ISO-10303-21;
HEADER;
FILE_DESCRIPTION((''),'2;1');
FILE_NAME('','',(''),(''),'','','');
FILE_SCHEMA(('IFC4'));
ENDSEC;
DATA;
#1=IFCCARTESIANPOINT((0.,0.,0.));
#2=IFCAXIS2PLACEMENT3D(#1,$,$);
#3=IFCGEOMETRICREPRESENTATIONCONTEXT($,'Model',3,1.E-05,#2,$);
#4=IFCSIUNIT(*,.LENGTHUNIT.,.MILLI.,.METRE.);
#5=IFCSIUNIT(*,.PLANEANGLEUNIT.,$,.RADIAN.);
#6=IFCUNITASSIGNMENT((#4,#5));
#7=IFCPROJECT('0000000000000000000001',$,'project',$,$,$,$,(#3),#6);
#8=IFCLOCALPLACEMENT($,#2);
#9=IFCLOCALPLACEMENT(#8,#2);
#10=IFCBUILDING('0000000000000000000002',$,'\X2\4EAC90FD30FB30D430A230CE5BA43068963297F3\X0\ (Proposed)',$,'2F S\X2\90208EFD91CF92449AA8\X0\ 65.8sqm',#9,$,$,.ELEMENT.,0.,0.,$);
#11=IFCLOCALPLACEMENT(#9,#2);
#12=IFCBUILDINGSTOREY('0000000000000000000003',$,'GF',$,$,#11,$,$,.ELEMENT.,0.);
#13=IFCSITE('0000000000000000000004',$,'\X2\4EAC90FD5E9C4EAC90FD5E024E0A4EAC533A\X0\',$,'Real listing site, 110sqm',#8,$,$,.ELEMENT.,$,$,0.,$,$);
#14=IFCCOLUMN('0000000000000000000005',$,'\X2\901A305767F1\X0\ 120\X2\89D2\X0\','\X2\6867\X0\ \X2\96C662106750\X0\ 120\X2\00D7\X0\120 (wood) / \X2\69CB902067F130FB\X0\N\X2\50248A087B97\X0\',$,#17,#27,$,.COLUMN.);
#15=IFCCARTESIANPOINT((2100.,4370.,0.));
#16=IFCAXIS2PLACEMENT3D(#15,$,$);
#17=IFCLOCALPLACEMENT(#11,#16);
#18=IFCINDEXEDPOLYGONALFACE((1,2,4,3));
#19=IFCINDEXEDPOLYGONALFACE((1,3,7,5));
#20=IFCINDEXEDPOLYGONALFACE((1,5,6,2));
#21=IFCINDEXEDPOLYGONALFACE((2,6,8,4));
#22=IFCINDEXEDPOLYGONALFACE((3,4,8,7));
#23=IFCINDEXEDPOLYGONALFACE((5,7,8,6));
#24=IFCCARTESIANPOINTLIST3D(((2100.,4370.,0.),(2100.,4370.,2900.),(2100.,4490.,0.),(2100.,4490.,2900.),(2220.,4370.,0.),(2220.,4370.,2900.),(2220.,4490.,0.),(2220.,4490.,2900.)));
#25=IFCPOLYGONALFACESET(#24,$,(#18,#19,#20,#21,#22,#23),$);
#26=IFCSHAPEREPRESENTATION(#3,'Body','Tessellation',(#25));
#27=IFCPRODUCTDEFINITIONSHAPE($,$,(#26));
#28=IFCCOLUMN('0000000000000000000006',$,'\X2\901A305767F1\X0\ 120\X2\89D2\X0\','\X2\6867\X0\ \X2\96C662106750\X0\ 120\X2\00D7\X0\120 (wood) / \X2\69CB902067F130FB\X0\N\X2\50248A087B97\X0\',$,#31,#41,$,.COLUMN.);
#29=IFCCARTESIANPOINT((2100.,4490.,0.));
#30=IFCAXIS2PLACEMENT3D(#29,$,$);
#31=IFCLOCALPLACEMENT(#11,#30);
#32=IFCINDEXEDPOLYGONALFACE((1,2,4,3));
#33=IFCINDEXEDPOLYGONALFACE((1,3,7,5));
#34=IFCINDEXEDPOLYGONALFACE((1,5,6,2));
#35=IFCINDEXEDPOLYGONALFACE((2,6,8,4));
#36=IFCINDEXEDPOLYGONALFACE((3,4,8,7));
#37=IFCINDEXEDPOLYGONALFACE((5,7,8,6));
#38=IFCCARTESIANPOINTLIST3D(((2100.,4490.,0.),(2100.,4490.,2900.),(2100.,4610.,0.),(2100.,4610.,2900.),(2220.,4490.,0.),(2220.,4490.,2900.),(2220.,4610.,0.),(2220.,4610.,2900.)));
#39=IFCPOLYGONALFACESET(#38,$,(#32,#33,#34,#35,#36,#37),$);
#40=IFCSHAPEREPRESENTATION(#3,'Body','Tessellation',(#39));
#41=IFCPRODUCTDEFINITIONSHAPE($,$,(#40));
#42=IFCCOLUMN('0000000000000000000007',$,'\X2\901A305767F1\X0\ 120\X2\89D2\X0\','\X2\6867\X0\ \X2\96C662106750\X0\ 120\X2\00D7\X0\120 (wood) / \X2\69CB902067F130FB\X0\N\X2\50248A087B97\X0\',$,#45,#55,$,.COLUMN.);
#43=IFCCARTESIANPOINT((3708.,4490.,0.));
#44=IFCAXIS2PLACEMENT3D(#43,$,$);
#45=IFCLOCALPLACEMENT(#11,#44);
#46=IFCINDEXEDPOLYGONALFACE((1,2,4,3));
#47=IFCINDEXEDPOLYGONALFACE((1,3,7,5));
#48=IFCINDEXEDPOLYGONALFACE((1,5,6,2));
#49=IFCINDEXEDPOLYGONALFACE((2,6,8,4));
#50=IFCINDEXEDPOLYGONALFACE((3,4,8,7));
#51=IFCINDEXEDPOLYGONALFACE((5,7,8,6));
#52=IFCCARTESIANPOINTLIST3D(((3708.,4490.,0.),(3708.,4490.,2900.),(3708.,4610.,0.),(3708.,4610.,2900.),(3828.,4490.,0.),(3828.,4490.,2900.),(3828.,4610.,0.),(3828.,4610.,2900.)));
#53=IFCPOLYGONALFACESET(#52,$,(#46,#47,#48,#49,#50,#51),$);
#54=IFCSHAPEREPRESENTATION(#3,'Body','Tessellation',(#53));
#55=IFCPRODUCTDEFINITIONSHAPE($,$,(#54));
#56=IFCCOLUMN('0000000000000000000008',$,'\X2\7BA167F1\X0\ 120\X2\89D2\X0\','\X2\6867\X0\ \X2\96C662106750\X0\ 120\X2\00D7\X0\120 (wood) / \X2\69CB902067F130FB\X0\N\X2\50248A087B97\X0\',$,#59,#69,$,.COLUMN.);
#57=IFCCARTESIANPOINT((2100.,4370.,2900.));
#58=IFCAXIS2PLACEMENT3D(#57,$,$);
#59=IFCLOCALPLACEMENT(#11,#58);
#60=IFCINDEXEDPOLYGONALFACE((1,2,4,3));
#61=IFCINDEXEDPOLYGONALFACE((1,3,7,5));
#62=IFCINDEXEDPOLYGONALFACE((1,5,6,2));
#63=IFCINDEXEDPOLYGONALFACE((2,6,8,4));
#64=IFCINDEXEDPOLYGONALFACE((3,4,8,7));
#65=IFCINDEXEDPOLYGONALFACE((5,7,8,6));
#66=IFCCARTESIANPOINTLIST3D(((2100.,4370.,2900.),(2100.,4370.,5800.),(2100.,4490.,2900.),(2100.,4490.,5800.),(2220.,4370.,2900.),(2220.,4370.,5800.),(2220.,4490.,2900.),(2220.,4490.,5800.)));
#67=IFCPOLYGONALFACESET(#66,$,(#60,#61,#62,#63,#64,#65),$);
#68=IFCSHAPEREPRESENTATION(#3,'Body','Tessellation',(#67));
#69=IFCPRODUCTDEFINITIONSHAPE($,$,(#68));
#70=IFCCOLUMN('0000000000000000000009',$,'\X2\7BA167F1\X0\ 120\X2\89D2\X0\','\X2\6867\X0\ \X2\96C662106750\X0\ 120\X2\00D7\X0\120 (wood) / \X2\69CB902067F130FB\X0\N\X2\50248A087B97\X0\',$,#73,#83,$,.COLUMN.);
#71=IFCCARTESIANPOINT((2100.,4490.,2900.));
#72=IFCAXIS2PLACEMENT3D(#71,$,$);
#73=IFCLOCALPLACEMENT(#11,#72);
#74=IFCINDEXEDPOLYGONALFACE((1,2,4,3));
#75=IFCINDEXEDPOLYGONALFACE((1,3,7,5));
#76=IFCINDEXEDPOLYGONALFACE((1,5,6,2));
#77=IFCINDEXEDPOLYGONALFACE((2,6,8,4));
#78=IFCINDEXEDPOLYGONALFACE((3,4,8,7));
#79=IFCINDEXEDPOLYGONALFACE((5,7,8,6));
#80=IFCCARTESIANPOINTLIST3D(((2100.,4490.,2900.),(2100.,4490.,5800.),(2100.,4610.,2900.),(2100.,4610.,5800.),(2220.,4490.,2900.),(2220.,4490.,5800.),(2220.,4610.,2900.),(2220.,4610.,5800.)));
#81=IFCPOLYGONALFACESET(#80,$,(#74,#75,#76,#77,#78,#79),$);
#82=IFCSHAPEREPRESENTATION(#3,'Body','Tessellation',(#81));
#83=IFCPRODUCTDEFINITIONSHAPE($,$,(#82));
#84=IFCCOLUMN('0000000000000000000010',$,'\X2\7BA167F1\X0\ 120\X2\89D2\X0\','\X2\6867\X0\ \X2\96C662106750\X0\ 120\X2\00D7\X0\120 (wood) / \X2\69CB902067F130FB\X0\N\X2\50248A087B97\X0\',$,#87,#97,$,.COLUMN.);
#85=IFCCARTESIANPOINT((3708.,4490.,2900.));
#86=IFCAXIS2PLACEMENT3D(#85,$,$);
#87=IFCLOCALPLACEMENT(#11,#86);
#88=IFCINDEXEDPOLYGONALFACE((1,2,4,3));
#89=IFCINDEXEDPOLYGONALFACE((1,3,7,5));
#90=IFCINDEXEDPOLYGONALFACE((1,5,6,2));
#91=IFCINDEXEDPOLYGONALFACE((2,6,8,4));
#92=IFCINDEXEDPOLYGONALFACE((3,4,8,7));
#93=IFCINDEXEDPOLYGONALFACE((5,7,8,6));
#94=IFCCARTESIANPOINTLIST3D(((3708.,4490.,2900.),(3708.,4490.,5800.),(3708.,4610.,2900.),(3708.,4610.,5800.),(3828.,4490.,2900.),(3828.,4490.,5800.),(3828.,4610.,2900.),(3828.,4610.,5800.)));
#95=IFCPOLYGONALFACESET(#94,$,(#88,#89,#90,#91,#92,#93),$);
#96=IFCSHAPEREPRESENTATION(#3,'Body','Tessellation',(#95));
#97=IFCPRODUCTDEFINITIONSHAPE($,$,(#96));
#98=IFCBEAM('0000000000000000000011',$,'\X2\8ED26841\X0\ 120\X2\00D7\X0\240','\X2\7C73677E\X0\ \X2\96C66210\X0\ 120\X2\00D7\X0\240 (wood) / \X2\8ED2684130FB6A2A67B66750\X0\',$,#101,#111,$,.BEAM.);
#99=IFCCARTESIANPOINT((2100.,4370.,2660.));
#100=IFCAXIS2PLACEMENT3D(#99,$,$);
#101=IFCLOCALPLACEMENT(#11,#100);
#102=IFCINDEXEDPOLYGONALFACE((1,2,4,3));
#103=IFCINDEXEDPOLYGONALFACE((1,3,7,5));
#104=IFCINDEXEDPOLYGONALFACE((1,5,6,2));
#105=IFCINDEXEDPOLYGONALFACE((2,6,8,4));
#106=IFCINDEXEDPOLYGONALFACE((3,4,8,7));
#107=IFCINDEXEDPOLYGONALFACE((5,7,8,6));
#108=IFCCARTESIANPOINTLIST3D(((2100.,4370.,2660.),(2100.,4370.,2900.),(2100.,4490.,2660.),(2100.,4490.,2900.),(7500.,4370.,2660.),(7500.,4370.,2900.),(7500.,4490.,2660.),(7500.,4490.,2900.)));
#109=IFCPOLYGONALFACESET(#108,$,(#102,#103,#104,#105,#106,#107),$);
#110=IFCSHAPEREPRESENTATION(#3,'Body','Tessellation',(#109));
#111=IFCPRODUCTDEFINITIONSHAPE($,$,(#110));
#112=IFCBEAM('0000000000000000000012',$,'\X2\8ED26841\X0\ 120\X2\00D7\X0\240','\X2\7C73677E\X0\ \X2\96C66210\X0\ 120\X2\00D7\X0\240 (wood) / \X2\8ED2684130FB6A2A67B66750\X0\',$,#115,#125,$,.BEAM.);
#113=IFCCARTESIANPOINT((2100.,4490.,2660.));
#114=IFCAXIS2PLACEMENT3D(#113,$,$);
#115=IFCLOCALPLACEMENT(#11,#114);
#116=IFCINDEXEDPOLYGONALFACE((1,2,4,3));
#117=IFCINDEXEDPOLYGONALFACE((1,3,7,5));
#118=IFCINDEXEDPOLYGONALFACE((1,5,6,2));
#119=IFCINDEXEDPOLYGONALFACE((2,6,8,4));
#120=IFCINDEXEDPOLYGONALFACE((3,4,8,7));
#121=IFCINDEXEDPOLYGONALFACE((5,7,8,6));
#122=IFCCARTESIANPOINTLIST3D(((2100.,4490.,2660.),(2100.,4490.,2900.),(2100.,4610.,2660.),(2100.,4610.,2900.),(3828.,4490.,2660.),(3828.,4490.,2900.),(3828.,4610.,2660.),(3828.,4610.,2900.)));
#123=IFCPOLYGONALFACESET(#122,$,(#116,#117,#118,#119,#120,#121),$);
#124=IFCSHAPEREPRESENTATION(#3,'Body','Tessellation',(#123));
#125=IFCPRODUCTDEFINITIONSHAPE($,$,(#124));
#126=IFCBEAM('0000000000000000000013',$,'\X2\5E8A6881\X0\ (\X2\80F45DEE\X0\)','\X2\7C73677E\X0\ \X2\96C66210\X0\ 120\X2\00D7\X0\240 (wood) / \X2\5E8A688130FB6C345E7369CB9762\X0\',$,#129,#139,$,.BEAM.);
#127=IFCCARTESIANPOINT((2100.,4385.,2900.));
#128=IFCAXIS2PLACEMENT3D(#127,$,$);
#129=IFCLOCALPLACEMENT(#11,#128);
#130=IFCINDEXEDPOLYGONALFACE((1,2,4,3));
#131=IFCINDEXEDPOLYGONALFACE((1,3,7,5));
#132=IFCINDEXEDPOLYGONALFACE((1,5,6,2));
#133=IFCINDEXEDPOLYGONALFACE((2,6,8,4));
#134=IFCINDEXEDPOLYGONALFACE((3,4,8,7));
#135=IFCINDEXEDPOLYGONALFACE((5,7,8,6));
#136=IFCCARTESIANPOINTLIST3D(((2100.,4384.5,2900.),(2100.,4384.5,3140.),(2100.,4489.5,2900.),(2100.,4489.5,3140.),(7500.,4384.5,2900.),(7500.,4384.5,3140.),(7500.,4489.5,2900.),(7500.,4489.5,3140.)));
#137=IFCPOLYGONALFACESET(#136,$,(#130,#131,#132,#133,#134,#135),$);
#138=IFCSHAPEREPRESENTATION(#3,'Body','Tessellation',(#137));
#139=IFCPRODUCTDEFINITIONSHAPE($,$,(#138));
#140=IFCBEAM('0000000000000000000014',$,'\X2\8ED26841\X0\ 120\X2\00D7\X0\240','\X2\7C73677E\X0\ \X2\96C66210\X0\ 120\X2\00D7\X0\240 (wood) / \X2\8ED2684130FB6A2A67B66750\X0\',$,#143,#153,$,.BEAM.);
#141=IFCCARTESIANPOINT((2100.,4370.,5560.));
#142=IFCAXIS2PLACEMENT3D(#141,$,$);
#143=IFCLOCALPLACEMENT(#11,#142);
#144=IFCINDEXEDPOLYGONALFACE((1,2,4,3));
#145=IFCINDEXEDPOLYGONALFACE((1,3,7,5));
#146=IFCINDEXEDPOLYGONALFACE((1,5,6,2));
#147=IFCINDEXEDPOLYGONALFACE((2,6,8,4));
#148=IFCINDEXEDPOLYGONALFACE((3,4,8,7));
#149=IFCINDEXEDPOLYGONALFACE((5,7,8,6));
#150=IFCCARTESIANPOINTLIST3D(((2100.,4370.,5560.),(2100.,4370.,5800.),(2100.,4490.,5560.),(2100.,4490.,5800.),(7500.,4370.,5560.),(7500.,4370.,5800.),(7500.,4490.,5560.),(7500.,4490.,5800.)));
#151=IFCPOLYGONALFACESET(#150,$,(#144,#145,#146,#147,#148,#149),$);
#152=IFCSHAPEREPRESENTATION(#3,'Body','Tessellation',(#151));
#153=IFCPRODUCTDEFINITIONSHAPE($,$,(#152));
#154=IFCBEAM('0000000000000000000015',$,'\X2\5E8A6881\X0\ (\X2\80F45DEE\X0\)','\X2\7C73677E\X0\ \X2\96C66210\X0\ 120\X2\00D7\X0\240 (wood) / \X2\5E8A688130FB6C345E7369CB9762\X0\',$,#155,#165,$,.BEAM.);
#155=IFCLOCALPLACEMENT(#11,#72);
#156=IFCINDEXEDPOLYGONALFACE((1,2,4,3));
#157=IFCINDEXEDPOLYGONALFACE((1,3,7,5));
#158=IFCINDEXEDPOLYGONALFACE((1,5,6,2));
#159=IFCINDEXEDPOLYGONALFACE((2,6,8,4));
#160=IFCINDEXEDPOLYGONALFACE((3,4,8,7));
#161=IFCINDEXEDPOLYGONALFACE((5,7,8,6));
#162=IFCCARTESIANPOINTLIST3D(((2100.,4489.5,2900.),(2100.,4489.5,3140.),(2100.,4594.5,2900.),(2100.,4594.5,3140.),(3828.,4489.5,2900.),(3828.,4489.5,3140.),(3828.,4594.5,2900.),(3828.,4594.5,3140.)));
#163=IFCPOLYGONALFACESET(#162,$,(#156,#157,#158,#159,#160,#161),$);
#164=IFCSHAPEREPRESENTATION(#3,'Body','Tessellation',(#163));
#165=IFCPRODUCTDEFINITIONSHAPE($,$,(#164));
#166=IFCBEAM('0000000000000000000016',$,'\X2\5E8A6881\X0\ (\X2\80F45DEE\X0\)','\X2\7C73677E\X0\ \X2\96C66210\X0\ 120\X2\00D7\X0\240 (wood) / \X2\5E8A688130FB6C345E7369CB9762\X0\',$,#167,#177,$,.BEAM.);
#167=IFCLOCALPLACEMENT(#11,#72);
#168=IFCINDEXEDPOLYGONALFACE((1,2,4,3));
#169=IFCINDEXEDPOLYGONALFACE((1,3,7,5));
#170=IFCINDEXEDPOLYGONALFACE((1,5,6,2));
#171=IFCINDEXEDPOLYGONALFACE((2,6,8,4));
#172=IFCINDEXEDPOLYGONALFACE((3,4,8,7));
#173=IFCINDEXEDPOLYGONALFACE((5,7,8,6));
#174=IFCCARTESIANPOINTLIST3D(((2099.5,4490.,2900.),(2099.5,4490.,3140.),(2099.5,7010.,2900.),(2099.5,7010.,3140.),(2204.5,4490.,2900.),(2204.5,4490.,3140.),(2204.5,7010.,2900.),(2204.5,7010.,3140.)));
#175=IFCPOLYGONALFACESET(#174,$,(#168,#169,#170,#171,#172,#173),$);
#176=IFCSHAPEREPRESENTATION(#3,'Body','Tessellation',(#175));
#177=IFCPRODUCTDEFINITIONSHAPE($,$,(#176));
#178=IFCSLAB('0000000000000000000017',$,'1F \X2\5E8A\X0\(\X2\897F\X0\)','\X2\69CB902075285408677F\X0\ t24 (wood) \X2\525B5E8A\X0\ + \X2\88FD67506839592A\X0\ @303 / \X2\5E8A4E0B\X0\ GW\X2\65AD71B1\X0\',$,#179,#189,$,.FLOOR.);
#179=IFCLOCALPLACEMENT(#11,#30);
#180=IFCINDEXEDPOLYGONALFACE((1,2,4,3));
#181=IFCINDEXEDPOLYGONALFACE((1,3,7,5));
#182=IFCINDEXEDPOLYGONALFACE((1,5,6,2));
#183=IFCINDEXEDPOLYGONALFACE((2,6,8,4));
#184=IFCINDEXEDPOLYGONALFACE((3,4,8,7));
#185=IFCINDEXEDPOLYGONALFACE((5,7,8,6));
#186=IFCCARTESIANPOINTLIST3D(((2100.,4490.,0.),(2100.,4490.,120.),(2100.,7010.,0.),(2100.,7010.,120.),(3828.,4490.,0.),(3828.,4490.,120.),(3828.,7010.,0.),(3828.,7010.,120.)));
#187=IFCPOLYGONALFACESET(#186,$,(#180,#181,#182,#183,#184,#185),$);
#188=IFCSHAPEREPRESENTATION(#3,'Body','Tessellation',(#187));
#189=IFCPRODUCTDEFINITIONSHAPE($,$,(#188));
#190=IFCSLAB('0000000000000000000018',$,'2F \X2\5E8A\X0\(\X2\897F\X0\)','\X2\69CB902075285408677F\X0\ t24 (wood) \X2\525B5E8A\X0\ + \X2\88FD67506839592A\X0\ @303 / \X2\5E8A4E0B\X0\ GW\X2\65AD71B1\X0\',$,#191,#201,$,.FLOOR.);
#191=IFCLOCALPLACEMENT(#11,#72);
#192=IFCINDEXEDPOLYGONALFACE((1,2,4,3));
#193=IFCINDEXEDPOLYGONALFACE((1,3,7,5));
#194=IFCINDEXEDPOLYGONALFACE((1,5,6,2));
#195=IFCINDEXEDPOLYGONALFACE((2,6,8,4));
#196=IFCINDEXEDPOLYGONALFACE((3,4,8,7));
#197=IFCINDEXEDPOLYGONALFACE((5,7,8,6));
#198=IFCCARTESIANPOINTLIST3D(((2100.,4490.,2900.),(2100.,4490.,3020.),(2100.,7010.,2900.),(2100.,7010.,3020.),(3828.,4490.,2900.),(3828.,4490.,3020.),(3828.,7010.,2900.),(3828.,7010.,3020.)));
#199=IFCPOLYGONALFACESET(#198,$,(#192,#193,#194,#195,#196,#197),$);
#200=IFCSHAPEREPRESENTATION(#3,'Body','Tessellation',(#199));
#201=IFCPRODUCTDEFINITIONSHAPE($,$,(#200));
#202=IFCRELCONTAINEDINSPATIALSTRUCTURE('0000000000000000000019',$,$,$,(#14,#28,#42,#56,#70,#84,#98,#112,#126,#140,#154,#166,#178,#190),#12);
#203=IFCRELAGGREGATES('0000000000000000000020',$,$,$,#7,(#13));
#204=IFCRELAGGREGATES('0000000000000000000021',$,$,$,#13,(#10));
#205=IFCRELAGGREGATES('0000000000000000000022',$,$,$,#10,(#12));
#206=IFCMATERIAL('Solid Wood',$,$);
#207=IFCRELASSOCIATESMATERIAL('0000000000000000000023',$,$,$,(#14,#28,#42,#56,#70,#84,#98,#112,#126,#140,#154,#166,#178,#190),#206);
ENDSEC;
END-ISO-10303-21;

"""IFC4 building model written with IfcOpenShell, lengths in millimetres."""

from ifc_helpers import new_model, si_unit, frame, frame_2d, origin, place, context, project, spatial, rectangle, extrude, material, element, save


model = new_model("IFC4")

# Units and contexts
model_context = context("Model", 3, precision=1e-05, world=origin())
ifc_project = project(units=[si_unit("LENGTHUNIT", "METRE", prefix="MILLI"), si_unit("PLANEANGLEUNIT", "RADIAN")], contexts=[model_context])

# Site, building, storey
site_placement = place(None, origin())
site = spatial("IfcSite", under=ifc_project, at=site_placement, Name="京都府京都市上京区", ObjectType="Real listing site, 110sqm", CompositionType="ELEMENT", RefElevation=0.0)
building_placement = place(site_placement, origin())
building = spatial("IfcBuilding", under=site, at=building_placement, Name="京都・ピアノ室と防音 (Proposed)", ObjectType="2F S造軽量鉄骨 65.8sqm", CompositionType="ELEMENT", ElevationOfRefHeight=0.0, ElevationOfTerrain=0.0)
storey_placement = place(building_placement, origin())
storey = spatial("IfcBuildingStorey", under=building, at=storey_placement, Name="GF", CompositionType="ELEMENT", Elevation=0.0)

# Columns
ifc_material_1 = material(Name="Solid Wood")
column_1_placement = place(storey_placement, frame((2100.0, 4370.0, 0.0)))
element("IfcColumn", 1, at=column_1_placement, inside=storey, material=ifc_material_1, Name="通し柱 120角", Description="桧 集成材 120×120 (wood) / 構造柱・N値計算", PredefinedType="COLUMN", context=model_context, shape_type="SweptSolid", body=[
    extrude(rectangle(XDim=120.0, YDim=120.0, at=frame_2d((60.0, 60.0))), frame((2100.0, 4370.0, 0.0)), (0.0, 0.0, 1.0), 2900.0),
])
column_2_placement = place(storey_placement, frame((2100.0, 4490.0, 0.0)))
element("IfcColumn", 2, at=column_2_placement, inside=storey, material=ifc_material_1, Name="通し柱 120角", Description="桧 集成材 120×120 (wood) / 構造柱・N値計算", PredefinedType="COLUMN", context=model_context, shape_type="SweptSolid", body=[
    extrude(rectangle(XDim=120.0, YDim=120.0, at=frame_2d((60.0, 60.0))), frame((2100.0, 4490.0, 0.0)), (0.0, 0.0, 1.0), 2900.0),
])
column_3_placement = place(storey_placement, frame((3708.0, 4490.0, 0.0)))
element("IfcColumn", 3, at=column_3_placement, inside=storey, material=ifc_material_1, Name="通し柱 120角", Description="桧 集成材 120×120 (wood) / 構造柱・N値計算", PredefinedType="COLUMN", context=model_context, shape_type="SweptSolid", body=[
    extrude(rectangle(XDim=120.0, YDim=120.0, at=frame_2d((60.0, 60.0))), frame((3708.0, 4490.0, 0.0)), (0.0, 0.0, 1.0), 2900.0),
])
column_4_placement = place(storey_placement, frame((2100.0, 4370.0, 2900.0)))
element("IfcColumn", 4, at=column_4_placement, inside=storey, material=ifc_material_1, Name="管柱 120角", Description="桧 集成材 120×120 (wood) / 構造柱・N値計算", PredefinedType="COLUMN", context=model_context, shape_type="SweptSolid", body=[
    extrude(rectangle(XDim=120.0, YDim=120.0, at=frame_2d((60.0, 60.0))), frame((2100.0, 4370.0, 2900.0)), (0.0, 0.0, 1.0), 2900.0),
])
column_5_placement = place(storey_placement, frame((2100.0, 4490.0, 2900.0)))
element("IfcColumn", 5, at=column_5_placement, inside=storey, material=ifc_material_1, Name="管柱 120角", Description="桧 集成材 120×120 (wood) / 構造柱・N値計算", PredefinedType="COLUMN", context=model_context, shape_type="SweptSolid", body=[
    extrude(rectangle(XDim=120.0, YDim=120.0, at=frame_2d((60.0, 60.0))), frame((2100.0, 4490.0, 2900.0)), (0.0, 0.0, 1.0), 2900.0),
])
column_6_placement = place(storey_placement, frame((3708.0, 4490.0, 2900.0)))
element("IfcColumn", 6, at=column_6_placement, inside=storey, material=ifc_material_1, Name="管柱 120角", Description="桧 集成材 120×120 (wood) / 構造柱・N値計算", PredefinedType="COLUMN", context=model_context, shape_type="SweptSolid", body=[
    extrude(rectangle(XDim=120.0, YDim=120.0, at=frame_2d((60.0, 60.0))), frame((3708.0, 4490.0, 2900.0)), (0.0, 0.0, 1.0), 2900.0),
])

# Beams
beam_1_placement = place(storey_placement, frame((2100.0, 4370.0, 2660.0)))
element("IfcBeam", 7, at=beam_1_placement, inside=storey, material=ifc_material_1, Name="軒桁 120×240", Description="米松 集成 120×240 (wood) / 軒桁・横架材", PredefinedType="BEAM", context=model_context, shape_type="SweptSolid", body=[
    extrude(rectangle(XDim=5400.0, YDim=120.0, at=frame_2d((2700.0, 60.0))), frame((2100.0, 4370.0, 2660.0)), (0.0, 0.0, 1.0), 240.0),
])
beam_2_placement = place(storey_placement, frame((2100.0, 4490.0, 2660.0)))
element("IfcBeam", 8, at=beam_2_placement, inside=storey, material=ifc_material_1, Name="軒桁 120×240", Description="米松 集成 120×240 (wood) / 軒桁・横架材", PredefinedType="BEAM", context=model_context, shape_type="SweptSolid", body=[
    extrude(rectangle(XDim=1728.0, YDim=120.0, at=frame_2d((864.0, 60.0))), frame((2100.0, 4490.0, 2660.0)), (0.0, 0.0, 1.0), 240.0),
])
beam_3_placement = place(storey_placement, frame((2100.0, 4385.0, 2900.0)))
element("IfcBeam", 9, at=beam_3_placement, inside=storey, material=ifc_material_1, Name="床梁 (胴差)", Description="米松 集成 120×240 (wood) / 床梁・水平構面", PredefinedType="BEAM", context=model_context, shape_type="SweptSolid", body=[
    extrude(rectangle(XDim=5400.0, YDim=105.0, at=frame_2d((2700.0, 52.0))), frame((2100.0, 4385.0, 2900.0)), (0.0, 0.0, 1.0), 240.0),
])
beam_4_placement = place(storey_placement, frame((2100.0, 4370.0, 5560.0)))
element("IfcBeam", 10, at=beam_4_placement, inside=storey, material=ifc_material_1, Name="軒桁 120×240", Description="米松 集成 120×240 (wood) / 軒桁・横架材", PredefinedType="BEAM", context=model_context, shape_type="SweptSolid", body=[
    extrude(rectangle(XDim=5400.0, YDim=120.0, at=frame_2d((2700.0, 60.0))), frame((2100.0, 4370.0, 5560.0)), (0.0, 0.0, 1.0), 240.0),
])
beam_5_placement = place(storey_placement, frame((2100.0, 4490.0, 2900.0)))
element("IfcBeam", 11, at=beam_5_placement, inside=storey, material=ifc_material_1, Name="床梁 (胴差)", Description="米松 集成 120×240 (wood) / 床梁・水平構面", PredefinedType="BEAM", context=model_context, shape_type="SweptSolid", body=[
    extrude(rectangle(XDim=1728.0, YDim=105.0, at=frame_2d((864.0, 52.0))), frame((2100.0, 4490.0, 2900.0)), (0.0, 0.0, 1.0), 240.0),
])
beam_6_placement = place(storey_placement, frame((2100.0, 4490.0, 2900.0)))
element("IfcBeam", 12, at=beam_6_placement, inside=storey, material=ifc_material_1, Name="床梁 (胴差)", Description="米松 集成 120×240 (wood) / 床梁・水平構面", PredefinedType="BEAM", context=model_context, shape_type="SweptSolid", body=[
    extrude(rectangle(XDim=105.0, YDim=2520.0, at=frame_2d((52.0, 1260.0))), frame((2100.0, 4490.0, 2900.0)), (0.0, 0.0, 1.0), 240.0),
])

# Slabs
slab_1_placement = place(storey_placement, frame((2100.0, 4490.0, 0.0)))
element("IfcSlab", 13, at=slab_1_placement, inside=storey, material=ifc_material_1, Name="1F 床(西)", Description="構造用合板 t24 (wood) 剛床 + 製材根太 @303 / 床下 GW断熱", PredefinedType="FLOOR", context=model_context, shape_type="SweptSolid", body=[
    extrude(rectangle(XDim=1728.0, YDim=2520.0, at=frame_2d((864.0, 1260.0))), frame((2100.0, 4490.0, 0.0)), (0.0, 0.0, 1.0), 120.0),
])
slab_2_placement = place(storey_placement, frame((2100.0, 4490.0, 2900.0)))
element("IfcSlab", 14, at=slab_2_placement, inside=storey, material=ifc_material_1, Name="2F 床(西)", Description="構造用合板 t24 (wood) 剛床 + 製材根太 @303 / 床下 GW断熱", PredefinedType="FLOOR", context=model_context, shape_type="SweptSolid", body=[
    extrude(rectangle(XDim=1728.0, YDim=2520.0, at=frame_2d((864.0, 1260.0))), frame((2100.0, 4490.0, 2900.0)), (0.0, 0.0, 1.0), 120.0),
])

save(model, "model.ifc")
